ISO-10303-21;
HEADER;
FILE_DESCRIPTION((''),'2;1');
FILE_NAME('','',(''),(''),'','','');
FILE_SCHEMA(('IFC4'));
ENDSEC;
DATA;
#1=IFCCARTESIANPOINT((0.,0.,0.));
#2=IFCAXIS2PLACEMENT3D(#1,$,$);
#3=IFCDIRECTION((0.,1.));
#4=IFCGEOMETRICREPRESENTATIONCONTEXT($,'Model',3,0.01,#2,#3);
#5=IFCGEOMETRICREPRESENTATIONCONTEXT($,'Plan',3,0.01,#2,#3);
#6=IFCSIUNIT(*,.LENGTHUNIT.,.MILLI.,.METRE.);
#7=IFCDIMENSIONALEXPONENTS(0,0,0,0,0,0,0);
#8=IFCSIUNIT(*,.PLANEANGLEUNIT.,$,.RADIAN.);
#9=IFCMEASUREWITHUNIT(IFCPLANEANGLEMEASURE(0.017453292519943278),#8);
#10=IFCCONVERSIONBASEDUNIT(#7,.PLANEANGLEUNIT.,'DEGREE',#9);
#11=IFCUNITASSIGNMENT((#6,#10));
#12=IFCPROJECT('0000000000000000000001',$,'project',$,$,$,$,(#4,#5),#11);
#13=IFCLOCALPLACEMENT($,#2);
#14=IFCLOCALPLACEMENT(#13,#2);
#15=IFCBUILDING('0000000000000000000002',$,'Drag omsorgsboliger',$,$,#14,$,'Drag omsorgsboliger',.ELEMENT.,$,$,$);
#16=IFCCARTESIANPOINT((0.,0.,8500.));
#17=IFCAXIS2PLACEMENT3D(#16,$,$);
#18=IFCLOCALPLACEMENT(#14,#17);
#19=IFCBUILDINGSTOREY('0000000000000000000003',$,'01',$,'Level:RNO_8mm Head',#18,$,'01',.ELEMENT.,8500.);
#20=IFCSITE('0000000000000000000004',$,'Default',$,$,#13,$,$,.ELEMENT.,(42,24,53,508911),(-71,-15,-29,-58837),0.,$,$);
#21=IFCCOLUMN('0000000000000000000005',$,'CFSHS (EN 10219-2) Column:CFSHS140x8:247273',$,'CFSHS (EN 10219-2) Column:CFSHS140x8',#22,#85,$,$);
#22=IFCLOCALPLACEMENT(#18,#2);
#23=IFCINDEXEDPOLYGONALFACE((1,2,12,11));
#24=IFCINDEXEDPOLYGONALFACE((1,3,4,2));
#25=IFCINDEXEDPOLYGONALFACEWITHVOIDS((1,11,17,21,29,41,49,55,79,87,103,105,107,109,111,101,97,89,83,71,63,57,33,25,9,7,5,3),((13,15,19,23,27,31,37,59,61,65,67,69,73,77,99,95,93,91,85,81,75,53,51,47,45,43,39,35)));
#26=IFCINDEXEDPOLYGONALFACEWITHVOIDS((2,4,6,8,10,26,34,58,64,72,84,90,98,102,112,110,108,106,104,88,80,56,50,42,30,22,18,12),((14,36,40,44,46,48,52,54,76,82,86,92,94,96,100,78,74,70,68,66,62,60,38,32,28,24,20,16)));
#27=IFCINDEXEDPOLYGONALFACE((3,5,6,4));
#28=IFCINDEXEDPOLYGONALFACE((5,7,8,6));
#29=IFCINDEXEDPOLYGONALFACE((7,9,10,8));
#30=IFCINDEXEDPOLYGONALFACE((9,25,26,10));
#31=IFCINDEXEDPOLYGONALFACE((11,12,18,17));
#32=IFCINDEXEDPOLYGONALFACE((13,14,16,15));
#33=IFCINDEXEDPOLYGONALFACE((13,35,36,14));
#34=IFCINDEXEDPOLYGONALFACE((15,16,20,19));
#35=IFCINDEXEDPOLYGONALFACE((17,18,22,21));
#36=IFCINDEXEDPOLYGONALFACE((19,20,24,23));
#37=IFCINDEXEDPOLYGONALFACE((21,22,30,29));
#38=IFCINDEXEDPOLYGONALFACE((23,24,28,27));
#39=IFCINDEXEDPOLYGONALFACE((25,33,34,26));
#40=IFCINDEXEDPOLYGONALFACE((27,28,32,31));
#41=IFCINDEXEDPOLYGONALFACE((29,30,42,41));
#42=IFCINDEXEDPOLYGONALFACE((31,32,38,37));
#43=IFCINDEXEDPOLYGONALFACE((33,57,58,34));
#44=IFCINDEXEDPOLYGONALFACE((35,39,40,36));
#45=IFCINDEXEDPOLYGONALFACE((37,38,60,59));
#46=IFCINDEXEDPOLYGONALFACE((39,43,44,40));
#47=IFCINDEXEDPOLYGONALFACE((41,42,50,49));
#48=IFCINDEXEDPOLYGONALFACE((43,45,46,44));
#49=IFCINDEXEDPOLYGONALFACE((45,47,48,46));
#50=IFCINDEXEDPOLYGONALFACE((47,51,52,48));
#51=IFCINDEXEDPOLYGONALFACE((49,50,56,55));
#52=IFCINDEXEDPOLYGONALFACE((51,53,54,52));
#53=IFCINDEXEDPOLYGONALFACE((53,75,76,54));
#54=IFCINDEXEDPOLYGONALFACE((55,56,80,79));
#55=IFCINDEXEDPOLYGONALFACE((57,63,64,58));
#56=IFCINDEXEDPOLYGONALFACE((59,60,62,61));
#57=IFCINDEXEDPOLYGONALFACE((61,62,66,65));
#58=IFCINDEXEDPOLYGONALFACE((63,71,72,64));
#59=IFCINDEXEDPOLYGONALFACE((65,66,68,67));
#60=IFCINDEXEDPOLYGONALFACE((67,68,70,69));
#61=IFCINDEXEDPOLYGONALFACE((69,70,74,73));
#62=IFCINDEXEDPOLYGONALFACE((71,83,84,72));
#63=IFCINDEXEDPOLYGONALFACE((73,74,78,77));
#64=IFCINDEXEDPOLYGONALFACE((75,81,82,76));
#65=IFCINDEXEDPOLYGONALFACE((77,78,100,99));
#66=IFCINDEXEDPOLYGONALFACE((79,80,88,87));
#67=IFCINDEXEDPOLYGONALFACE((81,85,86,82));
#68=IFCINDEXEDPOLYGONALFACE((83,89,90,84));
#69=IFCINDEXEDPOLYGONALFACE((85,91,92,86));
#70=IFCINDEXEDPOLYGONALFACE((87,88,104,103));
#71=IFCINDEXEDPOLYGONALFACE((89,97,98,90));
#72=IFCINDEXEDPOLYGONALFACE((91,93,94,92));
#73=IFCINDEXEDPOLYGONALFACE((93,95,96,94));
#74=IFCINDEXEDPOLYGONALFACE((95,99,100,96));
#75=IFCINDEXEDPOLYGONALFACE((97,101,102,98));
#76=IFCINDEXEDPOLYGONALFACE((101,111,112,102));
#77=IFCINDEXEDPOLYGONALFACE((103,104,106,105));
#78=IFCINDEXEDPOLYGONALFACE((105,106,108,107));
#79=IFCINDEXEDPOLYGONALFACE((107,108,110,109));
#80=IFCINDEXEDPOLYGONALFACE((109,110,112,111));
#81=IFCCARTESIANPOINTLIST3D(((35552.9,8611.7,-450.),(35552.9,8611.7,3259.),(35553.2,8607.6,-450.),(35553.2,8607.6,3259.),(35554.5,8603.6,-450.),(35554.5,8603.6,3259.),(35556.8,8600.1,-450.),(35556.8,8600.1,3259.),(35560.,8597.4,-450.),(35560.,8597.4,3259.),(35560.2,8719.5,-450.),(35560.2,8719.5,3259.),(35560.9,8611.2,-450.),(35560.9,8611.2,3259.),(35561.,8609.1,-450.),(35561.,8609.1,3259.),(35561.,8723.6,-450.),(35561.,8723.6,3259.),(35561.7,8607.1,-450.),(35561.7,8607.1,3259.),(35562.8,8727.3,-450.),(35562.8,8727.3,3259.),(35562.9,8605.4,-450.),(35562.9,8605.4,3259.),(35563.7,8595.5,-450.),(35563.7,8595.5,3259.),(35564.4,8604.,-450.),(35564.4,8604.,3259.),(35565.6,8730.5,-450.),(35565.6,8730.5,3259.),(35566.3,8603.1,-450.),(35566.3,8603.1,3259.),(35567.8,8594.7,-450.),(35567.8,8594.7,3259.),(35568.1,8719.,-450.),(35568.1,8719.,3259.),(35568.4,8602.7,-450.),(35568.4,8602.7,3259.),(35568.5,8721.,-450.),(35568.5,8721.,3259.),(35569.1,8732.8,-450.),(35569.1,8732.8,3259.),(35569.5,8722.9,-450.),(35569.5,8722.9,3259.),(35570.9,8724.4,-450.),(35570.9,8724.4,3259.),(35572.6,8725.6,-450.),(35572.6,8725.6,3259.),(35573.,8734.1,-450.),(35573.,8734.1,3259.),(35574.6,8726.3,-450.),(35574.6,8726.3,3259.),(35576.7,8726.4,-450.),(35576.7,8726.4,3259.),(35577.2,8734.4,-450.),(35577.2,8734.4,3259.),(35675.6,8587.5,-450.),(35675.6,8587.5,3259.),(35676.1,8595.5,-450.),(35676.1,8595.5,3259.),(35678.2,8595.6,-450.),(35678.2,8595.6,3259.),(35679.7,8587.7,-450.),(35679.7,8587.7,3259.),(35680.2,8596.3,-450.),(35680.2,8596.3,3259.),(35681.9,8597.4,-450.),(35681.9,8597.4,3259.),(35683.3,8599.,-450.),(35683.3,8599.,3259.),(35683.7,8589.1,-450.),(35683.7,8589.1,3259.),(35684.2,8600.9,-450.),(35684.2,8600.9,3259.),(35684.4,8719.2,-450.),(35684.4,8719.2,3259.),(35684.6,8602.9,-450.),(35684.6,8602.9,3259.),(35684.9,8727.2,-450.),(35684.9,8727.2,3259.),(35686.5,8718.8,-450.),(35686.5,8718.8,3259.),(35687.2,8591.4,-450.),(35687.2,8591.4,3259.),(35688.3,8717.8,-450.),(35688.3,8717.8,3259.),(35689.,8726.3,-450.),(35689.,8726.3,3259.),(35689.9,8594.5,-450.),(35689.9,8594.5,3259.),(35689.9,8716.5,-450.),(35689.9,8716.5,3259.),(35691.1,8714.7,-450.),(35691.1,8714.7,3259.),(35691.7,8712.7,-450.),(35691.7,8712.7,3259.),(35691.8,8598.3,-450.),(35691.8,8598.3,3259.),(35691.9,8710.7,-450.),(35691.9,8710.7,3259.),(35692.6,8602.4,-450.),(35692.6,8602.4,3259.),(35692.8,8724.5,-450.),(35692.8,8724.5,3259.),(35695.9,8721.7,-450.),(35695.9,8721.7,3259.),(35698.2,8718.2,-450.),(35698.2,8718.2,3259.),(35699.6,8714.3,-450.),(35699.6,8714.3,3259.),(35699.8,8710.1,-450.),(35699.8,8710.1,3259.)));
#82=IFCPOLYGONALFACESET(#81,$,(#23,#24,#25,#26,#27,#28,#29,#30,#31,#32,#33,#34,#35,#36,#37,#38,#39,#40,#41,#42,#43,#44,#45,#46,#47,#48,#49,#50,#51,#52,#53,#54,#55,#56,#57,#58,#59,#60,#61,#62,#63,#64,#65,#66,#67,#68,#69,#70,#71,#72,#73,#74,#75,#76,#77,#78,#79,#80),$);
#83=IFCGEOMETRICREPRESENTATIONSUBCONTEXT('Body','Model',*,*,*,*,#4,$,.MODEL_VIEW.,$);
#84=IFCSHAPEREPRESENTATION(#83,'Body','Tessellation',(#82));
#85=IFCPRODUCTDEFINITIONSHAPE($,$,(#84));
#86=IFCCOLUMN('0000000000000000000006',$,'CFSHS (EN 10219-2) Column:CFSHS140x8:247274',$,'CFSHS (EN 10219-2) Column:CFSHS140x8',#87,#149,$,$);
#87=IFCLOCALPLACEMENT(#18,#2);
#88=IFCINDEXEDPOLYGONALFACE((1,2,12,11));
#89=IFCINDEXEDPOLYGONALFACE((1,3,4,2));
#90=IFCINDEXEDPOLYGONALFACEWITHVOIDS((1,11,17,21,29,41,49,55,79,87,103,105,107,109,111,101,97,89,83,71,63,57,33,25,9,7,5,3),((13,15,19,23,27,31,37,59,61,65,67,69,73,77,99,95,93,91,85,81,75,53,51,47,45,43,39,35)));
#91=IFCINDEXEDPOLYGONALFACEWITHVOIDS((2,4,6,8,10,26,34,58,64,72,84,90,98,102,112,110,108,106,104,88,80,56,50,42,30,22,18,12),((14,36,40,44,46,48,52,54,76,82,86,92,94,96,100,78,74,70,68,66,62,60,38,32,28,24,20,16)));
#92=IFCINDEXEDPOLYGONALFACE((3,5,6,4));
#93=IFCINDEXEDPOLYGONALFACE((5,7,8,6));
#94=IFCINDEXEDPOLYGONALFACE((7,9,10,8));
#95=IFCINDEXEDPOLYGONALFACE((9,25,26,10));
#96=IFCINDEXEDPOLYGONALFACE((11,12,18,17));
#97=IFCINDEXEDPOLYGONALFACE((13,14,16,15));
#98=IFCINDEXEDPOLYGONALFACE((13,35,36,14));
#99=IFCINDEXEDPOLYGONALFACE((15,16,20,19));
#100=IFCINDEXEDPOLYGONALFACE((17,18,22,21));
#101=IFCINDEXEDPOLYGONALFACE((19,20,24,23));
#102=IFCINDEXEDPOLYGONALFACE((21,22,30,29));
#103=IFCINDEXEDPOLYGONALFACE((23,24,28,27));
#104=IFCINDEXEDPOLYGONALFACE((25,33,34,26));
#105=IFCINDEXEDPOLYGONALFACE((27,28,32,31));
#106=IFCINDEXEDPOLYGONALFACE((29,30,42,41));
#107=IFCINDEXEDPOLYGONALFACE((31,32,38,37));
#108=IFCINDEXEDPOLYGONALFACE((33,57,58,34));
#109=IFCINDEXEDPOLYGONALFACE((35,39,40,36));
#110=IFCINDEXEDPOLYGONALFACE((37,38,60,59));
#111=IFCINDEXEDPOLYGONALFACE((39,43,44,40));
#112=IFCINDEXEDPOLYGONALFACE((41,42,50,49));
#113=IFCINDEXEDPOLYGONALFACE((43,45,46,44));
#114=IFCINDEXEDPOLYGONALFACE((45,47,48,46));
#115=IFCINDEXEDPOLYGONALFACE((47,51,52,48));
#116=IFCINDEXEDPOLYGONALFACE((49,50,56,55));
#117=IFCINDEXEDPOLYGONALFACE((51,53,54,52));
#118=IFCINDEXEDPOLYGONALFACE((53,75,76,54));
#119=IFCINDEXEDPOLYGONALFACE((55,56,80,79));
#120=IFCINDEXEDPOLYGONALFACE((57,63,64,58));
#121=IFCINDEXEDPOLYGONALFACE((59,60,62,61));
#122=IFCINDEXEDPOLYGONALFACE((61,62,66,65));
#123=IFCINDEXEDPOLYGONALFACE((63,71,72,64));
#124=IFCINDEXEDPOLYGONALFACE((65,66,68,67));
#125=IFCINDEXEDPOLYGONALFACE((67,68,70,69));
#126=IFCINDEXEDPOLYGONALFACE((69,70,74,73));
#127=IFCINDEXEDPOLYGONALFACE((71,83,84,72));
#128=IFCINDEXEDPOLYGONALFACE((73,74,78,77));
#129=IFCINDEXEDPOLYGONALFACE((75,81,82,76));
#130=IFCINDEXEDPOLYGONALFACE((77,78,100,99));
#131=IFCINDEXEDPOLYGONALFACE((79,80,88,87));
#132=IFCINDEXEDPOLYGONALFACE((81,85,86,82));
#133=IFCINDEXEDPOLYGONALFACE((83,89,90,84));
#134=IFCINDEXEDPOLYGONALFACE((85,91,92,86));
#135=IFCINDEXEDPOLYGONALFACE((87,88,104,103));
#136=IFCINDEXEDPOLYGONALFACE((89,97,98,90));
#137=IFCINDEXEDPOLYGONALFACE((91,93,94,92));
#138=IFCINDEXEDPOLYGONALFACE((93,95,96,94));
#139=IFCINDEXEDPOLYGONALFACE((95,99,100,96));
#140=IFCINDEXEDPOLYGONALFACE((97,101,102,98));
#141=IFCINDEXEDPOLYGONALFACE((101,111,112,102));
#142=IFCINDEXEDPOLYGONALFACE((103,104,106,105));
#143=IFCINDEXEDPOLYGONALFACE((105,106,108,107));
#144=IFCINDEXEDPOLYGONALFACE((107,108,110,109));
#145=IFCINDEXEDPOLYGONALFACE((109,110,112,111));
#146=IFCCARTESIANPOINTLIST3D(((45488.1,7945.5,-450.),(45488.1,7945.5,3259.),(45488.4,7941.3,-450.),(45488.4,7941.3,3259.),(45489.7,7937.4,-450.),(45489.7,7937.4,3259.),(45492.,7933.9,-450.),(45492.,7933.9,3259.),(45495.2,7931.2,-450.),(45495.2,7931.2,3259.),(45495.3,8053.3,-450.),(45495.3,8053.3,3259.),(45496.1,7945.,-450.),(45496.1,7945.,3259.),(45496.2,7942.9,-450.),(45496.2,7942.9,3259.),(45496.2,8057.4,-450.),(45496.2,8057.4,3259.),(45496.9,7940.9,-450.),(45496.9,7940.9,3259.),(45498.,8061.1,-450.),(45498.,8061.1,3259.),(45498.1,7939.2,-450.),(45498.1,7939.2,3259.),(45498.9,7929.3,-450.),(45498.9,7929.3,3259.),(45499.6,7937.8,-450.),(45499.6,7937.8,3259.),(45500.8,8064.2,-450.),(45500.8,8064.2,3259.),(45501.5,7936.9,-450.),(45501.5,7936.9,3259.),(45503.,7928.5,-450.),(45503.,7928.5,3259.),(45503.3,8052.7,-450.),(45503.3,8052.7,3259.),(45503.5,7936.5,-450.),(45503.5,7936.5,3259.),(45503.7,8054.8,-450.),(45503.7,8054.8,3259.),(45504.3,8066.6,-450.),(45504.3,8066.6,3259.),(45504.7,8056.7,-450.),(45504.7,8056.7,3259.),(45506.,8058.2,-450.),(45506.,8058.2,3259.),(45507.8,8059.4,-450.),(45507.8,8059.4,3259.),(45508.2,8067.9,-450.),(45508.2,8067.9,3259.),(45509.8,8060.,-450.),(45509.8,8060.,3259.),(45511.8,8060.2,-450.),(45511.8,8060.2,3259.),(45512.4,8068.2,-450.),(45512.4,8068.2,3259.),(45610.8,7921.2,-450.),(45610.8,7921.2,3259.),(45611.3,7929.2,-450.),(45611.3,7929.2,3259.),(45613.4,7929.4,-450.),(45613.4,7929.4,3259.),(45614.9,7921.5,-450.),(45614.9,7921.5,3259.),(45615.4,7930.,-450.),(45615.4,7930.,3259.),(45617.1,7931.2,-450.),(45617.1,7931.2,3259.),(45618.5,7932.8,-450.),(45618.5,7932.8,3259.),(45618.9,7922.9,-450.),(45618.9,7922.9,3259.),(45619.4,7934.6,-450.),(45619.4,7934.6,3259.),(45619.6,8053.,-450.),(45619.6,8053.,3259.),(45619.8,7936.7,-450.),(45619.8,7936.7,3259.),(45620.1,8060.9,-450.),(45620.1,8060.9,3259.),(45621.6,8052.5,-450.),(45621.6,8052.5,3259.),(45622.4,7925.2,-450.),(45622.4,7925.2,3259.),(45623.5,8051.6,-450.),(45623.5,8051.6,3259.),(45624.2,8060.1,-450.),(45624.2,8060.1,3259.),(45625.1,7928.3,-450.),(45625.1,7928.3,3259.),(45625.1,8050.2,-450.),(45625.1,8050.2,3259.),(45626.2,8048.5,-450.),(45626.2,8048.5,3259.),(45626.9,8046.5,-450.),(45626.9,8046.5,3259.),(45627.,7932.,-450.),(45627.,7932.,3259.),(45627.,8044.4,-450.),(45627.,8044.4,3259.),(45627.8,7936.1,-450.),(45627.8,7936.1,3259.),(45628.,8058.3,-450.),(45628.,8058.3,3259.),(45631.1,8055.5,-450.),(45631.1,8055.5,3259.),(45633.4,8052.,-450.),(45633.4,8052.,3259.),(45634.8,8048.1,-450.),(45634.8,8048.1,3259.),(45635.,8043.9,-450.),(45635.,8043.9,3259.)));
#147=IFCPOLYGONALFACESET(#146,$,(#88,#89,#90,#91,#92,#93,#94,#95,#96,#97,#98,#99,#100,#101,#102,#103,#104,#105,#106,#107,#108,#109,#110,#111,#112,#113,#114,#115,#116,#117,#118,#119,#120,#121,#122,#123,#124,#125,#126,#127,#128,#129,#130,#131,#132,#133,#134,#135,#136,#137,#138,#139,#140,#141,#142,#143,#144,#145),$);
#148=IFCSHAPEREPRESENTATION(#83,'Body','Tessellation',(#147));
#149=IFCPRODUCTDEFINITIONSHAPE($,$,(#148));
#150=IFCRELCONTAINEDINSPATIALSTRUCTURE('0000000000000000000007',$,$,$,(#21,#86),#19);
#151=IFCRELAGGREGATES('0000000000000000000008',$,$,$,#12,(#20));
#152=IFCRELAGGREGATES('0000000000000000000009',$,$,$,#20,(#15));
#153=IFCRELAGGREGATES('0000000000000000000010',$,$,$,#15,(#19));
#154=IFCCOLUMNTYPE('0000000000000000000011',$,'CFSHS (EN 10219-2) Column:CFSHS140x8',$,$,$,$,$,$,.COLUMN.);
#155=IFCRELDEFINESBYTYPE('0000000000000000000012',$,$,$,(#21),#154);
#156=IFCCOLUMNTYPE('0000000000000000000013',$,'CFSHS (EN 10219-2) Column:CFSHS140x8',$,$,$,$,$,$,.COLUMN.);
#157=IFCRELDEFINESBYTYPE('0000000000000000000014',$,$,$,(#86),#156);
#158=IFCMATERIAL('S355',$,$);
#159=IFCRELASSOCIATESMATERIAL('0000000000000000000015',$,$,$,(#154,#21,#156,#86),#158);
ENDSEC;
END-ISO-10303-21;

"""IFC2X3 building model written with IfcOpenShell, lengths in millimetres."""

from ifc_helpers import new_model, entity, si_unit, converted_unit, direction, frame, frame_2d, origin, place, context, subcontext, project, spatial, polyline, circle_curve, parameter, trimmed, segment, composite_curve, outline, extrude, source, transform, mapped, material, type_object, type_shapes, element, save


model = new_model("IFC2X3")

# Units and contexts
model_context = context("Model", 3, precision=0.01, world=origin(), true_north=direction((0.0, 1.0)))
plan_context = context("Plan", 3, precision=0.01, world=origin(), true_north=direction((0.0, 1.0)))
body_context = subcontext(model_context, "Body", "Model", "MODEL_VIEW")
ifc_project = project(units=[si_unit("LENGTHUNIT", "METRE", prefix="MILLI"), converted_unit("PLANEANGLEUNIT", "DEGREE", entity("IfcPlaneAngleMeasure", 0.017453292519943278), si_unit("PLANEANGLEUNIT", "RADIAN"), dimensions=[0, 0, 0, 0, 0, 0, 0])], contexts=[model_context, plan_context])

# Site, building, storey
site_placement = place(None, origin())
site = spatial("IfcSite", under=ifc_project, at=site_placement, Name="Default", CompositionType="ELEMENT", RefLatitude=(42, 24, 53, 508911), RefLongitude=(-71, -15, -29, -58837), RefElevation=0.0)
building_placement = place(site_placement, origin())
building = spatial("IfcBuilding", under=site, at=building_placement, Name="Drag omsorgsboliger", LongName="Drag omsorgsboliger", CompositionType="ELEMENT")
storey_placement = place(building_placement, frame((0.0, 0.0, 8500.0)))
storey = spatial("IfcBuildingStorey", under=building, at=storey_placement, Name="01", ObjectType="Level:RNO_8mm Head", LongName="01", CompositionType="ELEMENT", Elevation=8500.0)

# Columns
ifc_material = material(Name="S355")
column_type_1 = type_object("IfcColumnType", Name="CFSHS (EN 10219-2) Column:CFSHS140x8", PredefinedType="COLUMN", material=ifc_material)
shared_shape_1 = source(origin(), body_context, "Body", "SweptSolid", [
    extrude(outline(composite_curve([segment(polyline([(-54.0, -70.0), (54.0, -70.0)]), True, "CONTINUOUS"), segment(trimmed(circle_curve(frame_2d((54.0, -54.0), x_axis=(-1.0, 0.0)), 16.0), [parameter(90.0)], [parameter(180.0)], True, "PARAMETER"), True, "CONTINUOUS"), segment(polyline([(70.0, -54.0), (70.0, 54.0)]), True, "CONTINUOUS"), segment(trimmed(circle_curve(frame_2d((54.0, 54.0), x_axis=(-1.0, 0.0)), 16.0), [parameter(180.0)], [parameter(270.0)], True, "PARAMETER"), True, "CONTINUOUS"), segment(polyline([(54.0, 70.0), (-54.0, 70.0)]), True, "CONTINUOUS"), segment(trimmed(circle_curve(frame_2d((-54.0, 54.0), x_axis=(-1.0, 0.0)), 16.0), [parameter(270.0)], [parameter(360.0)], True, "PARAMETER"), True, "CONTINUOUS"), segment(polyline([(-70.0, 54.0), (-70.0, -54.0)]), True, "CONTINUOUS"), segment(trimmed(circle_curve(frame_2d((-54.0, -54.0), x_axis=(-1.0, 0.0)), 16.0), [parameter(360.0)], [parameter(90.0)], True, "PARAMETER"), True, "CONTINUOUS")], self_intersect=False), holes=[composite_curve([segment(trimmed(circle_curve(frame_2d((-54.0, -54.0), x_axis=(-1.0, 0.0)), 8.0), [parameter(360.0)], [parameter(90.0)], True, "PARAMETER"), False, "CONTINUOUS"), segment(polyline([(-62.0, -54.0), (-62.0, 54.0)]), True, "CONTINUOUS"), segment(trimmed(circle_curve(frame_2d((-54.0, 54.0), x_axis=(-1.0, 0.0)), 8.0), [parameter(270.0)], [parameter(360.0)], True, "PARAMETER"), False, "CONTINUOUS"), segment(polyline([(-54.0, 62.0), (54.0, 62.0)]), True, "CONTINUOUS"), segment(trimmed(circle_curve(frame_2d((54.0, 54.0), x_axis=(-1.0, 0.0)), 8.0), [parameter(180.0)], [parameter(270.0)], True, "PARAMETER"), False, "CONTINUOUS"), segment(polyline([(62.0, 54.0), (62.0, -54.0)]), True, "CONTINUOUS"), segment(trimmed(circle_curve(frame_2d((54.0, -54.0), x_axis=(-1.0, 0.0)), 8.0), [parameter(90.0)], [parameter(180.0)], True, "PARAMETER"), False, "CONTINUOUS"), segment(polyline([(54.0, -62.0), (-54.0, -62.0)]), True, "CONTINUOUS")], self_intersect=False)]), frame((35626.4, 8660.9, 8050.0), z_axis=(0.0, 0.0, 1.0), x_axis=(-0.997758, 0.066923, 0.0)), (0.0, 0.0, 1.0), 3709.0),
])
type_shapes(column_type_1, [shared_shape_1])
column_1_placement = place(storey_placement, frame((0.0, 0.0, -8500.0)))
element("IfcColumn", 1, at=column_1_placement, inside=storey, type_object=column_type_1, material=ifc_material, Name="CFSHS (EN 10219-2) Column:CFSHS140x8:247273", ObjectType="CFSHS (EN 10219-2) Column:CFSHS140x8", context=body_context, shape_type="MappedRepresentation", body=[
    mapped(shared_shape_1, transform((0.0, 0.0, 0.0), scale=1.0)),
])
column_type_2 = type_object("IfcColumnType", Name="CFSHS (EN 10219-2) Column:CFSHS140x8", PredefinedType="COLUMN", material=ifc_material)
shared_shape_2 = source(origin(), body_context, "Body", "SweptSolid", [
    extrude(outline(composite_curve([segment(polyline([(-54.0, -70.0), (54.0, -70.0)]), True, "CONTINUOUS"), segment(trimmed(circle_curve(frame_2d((54.0, -54.0), x_axis=(-1.0, 0.0)), 16.0), [parameter(90.0)], [parameter(180.0)], True, "PARAMETER"), True, "CONTINUOUS"), segment(polyline([(70.0, -54.0), (70.0, 54.0)]), True, "CONTINUOUS"), segment(trimmed(circle_curve(frame_2d((54.0, 54.0), x_axis=(-1.0, 0.0)), 16.0), [parameter(180.0)], [parameter(270.0)], True, "PARAMETER"), True, "CONTINUOUS"), segment(polyline([(54.0, 70.0), (-54.0, 70.0)]), True, "CONTINUOUS"), segment(trimmed(circle_curve(frame_2d((-54.0, 54.0), x_axis=(-1.0, 0.0)), 16.0), [parameter(270.0)], [parameter(360.0)], True, "PARAMETER"), True, "CONTINUOUS"), segment(polyline([(-70.0, 54.0), (-70.0, -54.0)]), True, "CONTINUOUS"), segment(trimmed(circle_curve(frame_2d((-54.0, -54.0), x_axis=(-1.0, 0.0)), 16.0), [parameter(360.0)], [parameter(90.0)], True, "PARAMETER"), True, "CONTINUOUS")], self_intersect=False), holes=[composite_curve([segment(trimmed(circle_curve(frame_2d((-54.0, -54.0), x_axis=(-1.0, 0.0)), 8.0), [parameter(360.0)], [parameter(90.0)], True, "PARAMETER"), False, "CONTINUOUS"), segment(polyline([(-62.0, -54.0), (-62.0, 54.0)]), True, "CONTINUOUS"), segment(trimmed(circle_curve(frame_2d((-54.0, 54.0), x_axis=(-1.0, 0.0)), 8.0), [parameter(270.0)], [parameter(360.0)], True, "PARAMETER"), False, "CONTINUOUS"), segment(polyline([(-54.0, 62.0), (54.0, 62.0)]), True, "CONTINUOUS"), segment(trimmed(circle_curve(frame_2d((54.0, 54.0), x_axis=(-1.0, 0.0)), 8.0), [parameter(180.0)], [parameter(270.0)], True, "PARAMETER"), False, "CONTINUOUS"), segment(polyline([(62.0, 54.0), (62.0, -54.0)]), True, "CONTINUOUS"), segment(trimmed(circle_curve(frame_2d((54.0, -54.0), x_axis=(-1.0, 0.0)), 8.0), [parameter(90.0)], [parameter(180.0)], True, "PARAMETER"), False, "CONTINUOUS"), segment(polyline([(54.0, -62.0), (-54.0, -62.0)]), True, "CONTINUOUS")], self_intersect=False)]), frame((45561.6, 7994.7, 8050.0), z_axis=(0.0, 0.0, 1.0), x_axis=(-0.997758, 0.066923, 0.0)), (0.0, 0.0, 1.0), 3709.0),
])
type_shapes(column_type_2, [shared_shape_2])
column_2_placement = place(storey_placement, frame((0.0, 0.0, -8500.0)))
element("IfcColumn", 2, at=column_2_placement, inside=storey, type_object=column_type_2, material=ifc_material, Name="CFSHS (EN 10219-2) Column:CFSHS140x8:247274", ObjectType="CFSHS (EN 10219-2) Column:CFSHS140x8", context=body_context, shape_type="MappedRepresentation", body=[
    mapped(shared_shape_2, transform((0.0, 0.0, 0.0), scale=1.0)),
])

save(model, "model.ifc")
